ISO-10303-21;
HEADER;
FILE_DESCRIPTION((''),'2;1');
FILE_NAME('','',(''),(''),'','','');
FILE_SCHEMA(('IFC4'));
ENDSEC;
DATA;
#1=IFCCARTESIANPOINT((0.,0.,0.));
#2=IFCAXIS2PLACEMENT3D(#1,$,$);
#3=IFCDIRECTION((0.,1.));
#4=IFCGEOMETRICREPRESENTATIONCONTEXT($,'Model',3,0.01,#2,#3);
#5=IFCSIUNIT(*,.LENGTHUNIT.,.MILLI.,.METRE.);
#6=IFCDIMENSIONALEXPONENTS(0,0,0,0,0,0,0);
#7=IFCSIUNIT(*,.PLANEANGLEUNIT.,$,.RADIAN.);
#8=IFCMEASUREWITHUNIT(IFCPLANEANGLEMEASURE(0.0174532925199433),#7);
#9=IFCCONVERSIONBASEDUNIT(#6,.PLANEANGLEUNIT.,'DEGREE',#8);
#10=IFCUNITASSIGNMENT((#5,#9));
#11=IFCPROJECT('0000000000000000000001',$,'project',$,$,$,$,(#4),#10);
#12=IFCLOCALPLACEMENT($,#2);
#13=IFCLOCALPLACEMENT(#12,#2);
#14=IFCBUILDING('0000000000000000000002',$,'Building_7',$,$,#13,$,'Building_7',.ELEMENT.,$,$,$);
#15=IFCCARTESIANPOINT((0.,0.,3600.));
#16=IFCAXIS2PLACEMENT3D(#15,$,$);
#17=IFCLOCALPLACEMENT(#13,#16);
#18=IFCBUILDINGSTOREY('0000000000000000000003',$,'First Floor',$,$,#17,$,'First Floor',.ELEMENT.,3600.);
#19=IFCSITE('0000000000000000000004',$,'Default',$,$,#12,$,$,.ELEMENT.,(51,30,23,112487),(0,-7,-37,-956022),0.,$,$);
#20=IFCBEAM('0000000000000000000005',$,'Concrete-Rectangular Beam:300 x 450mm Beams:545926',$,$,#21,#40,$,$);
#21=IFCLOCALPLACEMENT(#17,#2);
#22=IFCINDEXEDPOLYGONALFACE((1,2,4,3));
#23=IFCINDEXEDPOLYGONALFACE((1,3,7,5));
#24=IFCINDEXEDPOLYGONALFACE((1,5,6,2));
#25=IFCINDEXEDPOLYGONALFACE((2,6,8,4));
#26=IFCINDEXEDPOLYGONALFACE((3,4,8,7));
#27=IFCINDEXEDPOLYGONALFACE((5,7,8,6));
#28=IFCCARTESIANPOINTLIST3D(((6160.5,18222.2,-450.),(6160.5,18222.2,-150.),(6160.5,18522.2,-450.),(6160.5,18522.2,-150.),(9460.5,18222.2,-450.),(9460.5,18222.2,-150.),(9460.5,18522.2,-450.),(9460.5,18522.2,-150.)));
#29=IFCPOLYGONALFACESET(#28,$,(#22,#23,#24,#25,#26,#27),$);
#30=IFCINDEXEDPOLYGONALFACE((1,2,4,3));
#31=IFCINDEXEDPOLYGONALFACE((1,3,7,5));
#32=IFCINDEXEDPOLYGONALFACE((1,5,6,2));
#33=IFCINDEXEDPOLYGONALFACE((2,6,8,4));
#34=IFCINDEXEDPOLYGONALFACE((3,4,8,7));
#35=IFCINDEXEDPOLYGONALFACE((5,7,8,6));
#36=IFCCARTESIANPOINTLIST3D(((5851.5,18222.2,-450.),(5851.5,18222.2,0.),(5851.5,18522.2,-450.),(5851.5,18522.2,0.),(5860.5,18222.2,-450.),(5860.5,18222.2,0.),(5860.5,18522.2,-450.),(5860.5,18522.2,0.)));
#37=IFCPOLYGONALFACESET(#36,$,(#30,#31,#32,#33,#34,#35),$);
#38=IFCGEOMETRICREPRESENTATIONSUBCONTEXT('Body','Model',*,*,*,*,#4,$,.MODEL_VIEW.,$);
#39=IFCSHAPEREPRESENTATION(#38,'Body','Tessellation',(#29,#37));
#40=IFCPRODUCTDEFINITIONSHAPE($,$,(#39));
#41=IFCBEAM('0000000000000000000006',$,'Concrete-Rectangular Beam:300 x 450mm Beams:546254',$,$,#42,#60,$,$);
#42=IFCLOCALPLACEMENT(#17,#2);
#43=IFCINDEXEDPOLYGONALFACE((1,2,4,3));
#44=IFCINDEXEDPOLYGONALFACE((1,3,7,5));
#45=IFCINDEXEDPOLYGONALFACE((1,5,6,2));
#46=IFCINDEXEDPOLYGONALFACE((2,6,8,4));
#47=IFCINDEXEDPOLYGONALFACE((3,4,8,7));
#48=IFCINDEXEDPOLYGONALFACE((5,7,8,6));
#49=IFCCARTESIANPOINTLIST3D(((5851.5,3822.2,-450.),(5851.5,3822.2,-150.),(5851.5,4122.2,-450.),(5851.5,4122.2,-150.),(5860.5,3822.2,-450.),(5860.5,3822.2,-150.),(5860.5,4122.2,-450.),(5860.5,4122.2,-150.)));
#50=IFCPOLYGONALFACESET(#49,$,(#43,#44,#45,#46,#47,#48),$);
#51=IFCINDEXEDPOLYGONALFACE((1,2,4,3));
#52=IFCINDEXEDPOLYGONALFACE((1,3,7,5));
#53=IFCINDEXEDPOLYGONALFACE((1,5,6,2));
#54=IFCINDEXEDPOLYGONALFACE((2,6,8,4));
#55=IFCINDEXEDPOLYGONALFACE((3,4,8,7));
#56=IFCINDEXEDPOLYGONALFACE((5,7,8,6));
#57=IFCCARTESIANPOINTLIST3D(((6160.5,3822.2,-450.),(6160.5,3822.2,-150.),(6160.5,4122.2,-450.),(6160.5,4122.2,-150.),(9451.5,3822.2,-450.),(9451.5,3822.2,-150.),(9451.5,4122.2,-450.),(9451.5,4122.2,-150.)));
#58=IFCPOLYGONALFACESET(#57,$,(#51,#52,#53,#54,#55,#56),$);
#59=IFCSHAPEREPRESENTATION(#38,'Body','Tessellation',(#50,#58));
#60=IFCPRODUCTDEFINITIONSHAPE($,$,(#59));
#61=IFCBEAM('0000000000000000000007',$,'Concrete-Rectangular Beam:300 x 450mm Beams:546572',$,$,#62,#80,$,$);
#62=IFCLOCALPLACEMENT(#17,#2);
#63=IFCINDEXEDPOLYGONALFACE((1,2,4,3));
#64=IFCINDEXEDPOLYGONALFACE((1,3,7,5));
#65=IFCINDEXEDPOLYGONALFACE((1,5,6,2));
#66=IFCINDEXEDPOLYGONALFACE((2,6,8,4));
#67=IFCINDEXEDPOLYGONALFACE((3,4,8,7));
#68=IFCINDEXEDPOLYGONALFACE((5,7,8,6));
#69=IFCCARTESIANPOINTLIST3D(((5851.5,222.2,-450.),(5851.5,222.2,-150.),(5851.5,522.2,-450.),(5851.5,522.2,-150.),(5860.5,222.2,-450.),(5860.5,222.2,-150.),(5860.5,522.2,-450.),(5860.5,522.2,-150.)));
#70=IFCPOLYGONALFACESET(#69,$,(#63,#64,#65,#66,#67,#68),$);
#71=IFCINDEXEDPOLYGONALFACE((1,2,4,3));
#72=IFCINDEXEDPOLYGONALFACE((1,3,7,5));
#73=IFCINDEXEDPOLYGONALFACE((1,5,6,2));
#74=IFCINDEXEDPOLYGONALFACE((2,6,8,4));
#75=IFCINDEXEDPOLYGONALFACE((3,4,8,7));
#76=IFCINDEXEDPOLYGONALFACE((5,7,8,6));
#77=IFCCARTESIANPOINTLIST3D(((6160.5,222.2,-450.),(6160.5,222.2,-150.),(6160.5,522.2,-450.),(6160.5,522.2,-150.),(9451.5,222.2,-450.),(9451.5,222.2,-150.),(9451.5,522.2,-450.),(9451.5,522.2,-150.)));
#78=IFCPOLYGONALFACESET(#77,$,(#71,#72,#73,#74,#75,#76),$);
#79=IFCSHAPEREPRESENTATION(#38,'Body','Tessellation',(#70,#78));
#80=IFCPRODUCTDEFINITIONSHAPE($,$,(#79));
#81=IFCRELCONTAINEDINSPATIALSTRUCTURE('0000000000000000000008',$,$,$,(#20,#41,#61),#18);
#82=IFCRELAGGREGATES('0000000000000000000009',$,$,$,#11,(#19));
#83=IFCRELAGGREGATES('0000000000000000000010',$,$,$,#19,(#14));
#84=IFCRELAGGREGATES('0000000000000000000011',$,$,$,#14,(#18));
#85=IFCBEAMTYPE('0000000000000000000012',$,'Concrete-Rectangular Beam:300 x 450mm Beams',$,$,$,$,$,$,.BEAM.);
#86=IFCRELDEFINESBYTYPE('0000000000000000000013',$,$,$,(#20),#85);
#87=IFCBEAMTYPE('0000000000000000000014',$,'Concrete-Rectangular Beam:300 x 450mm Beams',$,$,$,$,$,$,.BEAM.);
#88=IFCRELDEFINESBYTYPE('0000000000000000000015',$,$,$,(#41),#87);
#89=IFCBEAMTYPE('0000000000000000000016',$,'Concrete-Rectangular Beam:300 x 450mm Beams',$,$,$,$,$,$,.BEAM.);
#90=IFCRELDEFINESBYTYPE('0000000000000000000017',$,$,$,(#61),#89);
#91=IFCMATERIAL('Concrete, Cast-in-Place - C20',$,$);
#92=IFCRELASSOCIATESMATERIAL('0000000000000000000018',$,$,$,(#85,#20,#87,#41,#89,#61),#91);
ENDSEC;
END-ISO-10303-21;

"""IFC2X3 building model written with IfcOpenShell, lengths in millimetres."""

from ifc_helpers import new_model, entity, si_unit, converted_unit, direction, frame, frame_2d, origin, place, context, subcontext, project, spatial, rectangle, extrude, source, transform, mapped, material, type_object, type_shapes, element, save


model = new_model("IFC2X3")

# Units and contexts
model_context = context("Model", 3, precision=0.01, world=origin(), true_north=direction((0.0, 1.0)))
body_context = subcontext(model_context, "Body", "Model", "MODEL_VIEW")
ifc_project = project(units=[si_unit("LENGTHUNIT", "METRE", prefix="MILLI"), converted_unit("PLANEANGLEUNIT", "DEGREE", entity("IfcPlaneAngleMeasure", 0.0174532925199433), si_unit("PLANEANGLEUNIT", "RADIAN"), dimensions=[0, 0, 0, 0, 0, 0, 0])], contexts=[model_context])

# Site, building, storey
site_placement = place(None, origin())
site = spatial("IfcSite", under=ifc_project, at=site_placement, Name="Default", CompositionType="ELEMENT", RefLatitude=(51, 30, 23, 112487), RefLongitude=(0, -7, -37, -956022), RefElevation=0.0)
building_placement = place(site_placement, origin())
building = spatial("IfcBuilding", under=site, at=building_placement, Name="Building_7", LongName="Building_7", CompositionType="ELEMENT")
storey_placement = place(building_placement, frame((0.0, 0.0, 3600.0)))
storey = spatial("IfcBuildingStorey", under=building, at=storey_placement, Name="First Floor", LongName="First Floor", CompositionType="ELEMENT", Elevation=3600.0)

# Beams
ifc_material_1 = material(Name="Concrete, Cast-in-Place - C20")
beam_type_1 = type_object("IfcBeamType", Name="Concrete-Rectangular Beam:300 x 450mm Beams", PredefinedType="BEAM", material=ifc_material_1)
shared_shape_1 = source(origin(), body_context, "Body", "SweptSolid", [
    extrude(rectangle(XDim=300.0, YDim=300.0, at=frame_2d((0.0, 0.0), x_axis=(1.0, 0.0))), frame((6160.5, 18372.2, 3300.0), z_axis=(1.0, 0.0, 0.0), x_axis=(0.0, 0.0, -1.0)), (0.0, 0.0, 1.0), 3300.0),
    extrude(rectangle(XDim=450.0, YDim=300.0, at=frame_2d((0.0, 0.0), x_axis=(1.0, 0.0))), frame((5851.5, 18372.2, 3375.0), z_axis=(1.0, 0.0, 0.0), x_axis=(0.0, 0.0, -1.0)), (0.0, 0.0, 1.0), 8.9),
])
type_shapes(beam_type_1, [shared_shape_1])
beam_1_placement = place(storey_placement, frame((0.0, 0.0, -3600.0)))
element("IfcBeam", 1, at=beam_1_placement, inside=storey, type_object=beam_type_1, material=ifc_material_1, Name="Concrete-Rectangular Beam:300 x 450mm Beams:545926", context=body_context, shape_type="MappedRepresentation", body=[
    mapped(shared_shape_1, transform((0.0, 0.0, 0.0), scale=1.0)),
])
beam_type_2 = type_object("IfcBeamType", Name="Concrete-Rectangular Beam:300 x 450mm Beams", PredefinedType="BEAM", material=ifc_material_1)
shared_shape_2 = source(origin(), body_context, "Body", "SweptSolid", [
    extrude(rectangle(XDim=300.0, YDim=300.0, at=frame_2d((0.0, 0.0), x_axis=(1.0, 0.0))), frame((5860.5, 3972.2, 3300.0), z_axis=(-1.0, 0.0, 0.0), x_axis=(0.0, 0.0, -1.0)), (0.0, 0.0, 1.0), 8.9),
    extrude(rectangle(XDim=300.0, YDim=300.0, at=frame_2d((0.0, 0.0), x_axis=(1.0, 0.0))), frame((9451.5, 3972.2, 3300.0), z_axis=(-1.0, 0.0, 0.0), x_axis=(0.0, 0.0, -1.0)), (0.0, 0.0, 1.0), 3291.1),
])
type_shapes(beam_type_2, [shared_shape_2])
beam_2_placement = place(storey_placement, frame((0.0, 0.0, -3600.0)))
element("IfcBeam", 2, at=beam_2_placement, inside=storey, type_object=beam_type_2, material=ifc_material_1, Name="Concrete-Rectangular Beam:300 x 450mm Beams:546254", context=body_context, shape_type="MappedRepresentation", body=[
    mapped(shared_shape_2, transform((0.0, 0.0, 0.0), scale=1.0)),
])
beam_type_3 = type_object("IfcBeamType", Name="Concrete-Rectangular Beam:300 x 450mm Beams", PredefinedType="BEAM", material=ifc_material_1)
shared_shape_3 = source(origin(), body_context, "Body", "SweptSolid", [
    extrude(rectangle(XDim=300.0, YDim=300.0, at=frame_2d((0.0, 0.0), x_axis=(1.0, 0.0))), frame((5860.5, 372.2, 3300.0), z_axis=(-1.0, 0.0, 0.0), x_axis=(0.0, 0.0, -1.0)), (0.0, 0.0, 1.0), 8.9),
    extrude(rectangle(XDim=300.0, YDim=300.0, at=frame_2d((0.0, 0.0), x_axis=(1.0, 0.0))), frame((9451.5, 372.2, 3300.0), z_axis=(-1.0, 0.0, 0.0), x_axis=(0.0, 0.0, -1.0)), (0.0, 0.0, 1.0), 3291.1),
])
type_shapes(beam_type_3, [shared_shape_3])
beam_3_placement = place(storey_placement, frame((0.0, 0.0, -3600.0)))
element("IfcBeam", 3, at=beam_3_placement, inside=storey, type_object=beam_type_3, material=ifc_material_1, Name="Concrete-Rectangular Beam:300 x 450mm Beams:546572", context=body_context, shape_type="MappedRepresentation", body=[
    mapped(shared_shape_3, transform((0.0, 0.0, 0.0), scale=1.0)),
])

save(model, "model.ifc")
